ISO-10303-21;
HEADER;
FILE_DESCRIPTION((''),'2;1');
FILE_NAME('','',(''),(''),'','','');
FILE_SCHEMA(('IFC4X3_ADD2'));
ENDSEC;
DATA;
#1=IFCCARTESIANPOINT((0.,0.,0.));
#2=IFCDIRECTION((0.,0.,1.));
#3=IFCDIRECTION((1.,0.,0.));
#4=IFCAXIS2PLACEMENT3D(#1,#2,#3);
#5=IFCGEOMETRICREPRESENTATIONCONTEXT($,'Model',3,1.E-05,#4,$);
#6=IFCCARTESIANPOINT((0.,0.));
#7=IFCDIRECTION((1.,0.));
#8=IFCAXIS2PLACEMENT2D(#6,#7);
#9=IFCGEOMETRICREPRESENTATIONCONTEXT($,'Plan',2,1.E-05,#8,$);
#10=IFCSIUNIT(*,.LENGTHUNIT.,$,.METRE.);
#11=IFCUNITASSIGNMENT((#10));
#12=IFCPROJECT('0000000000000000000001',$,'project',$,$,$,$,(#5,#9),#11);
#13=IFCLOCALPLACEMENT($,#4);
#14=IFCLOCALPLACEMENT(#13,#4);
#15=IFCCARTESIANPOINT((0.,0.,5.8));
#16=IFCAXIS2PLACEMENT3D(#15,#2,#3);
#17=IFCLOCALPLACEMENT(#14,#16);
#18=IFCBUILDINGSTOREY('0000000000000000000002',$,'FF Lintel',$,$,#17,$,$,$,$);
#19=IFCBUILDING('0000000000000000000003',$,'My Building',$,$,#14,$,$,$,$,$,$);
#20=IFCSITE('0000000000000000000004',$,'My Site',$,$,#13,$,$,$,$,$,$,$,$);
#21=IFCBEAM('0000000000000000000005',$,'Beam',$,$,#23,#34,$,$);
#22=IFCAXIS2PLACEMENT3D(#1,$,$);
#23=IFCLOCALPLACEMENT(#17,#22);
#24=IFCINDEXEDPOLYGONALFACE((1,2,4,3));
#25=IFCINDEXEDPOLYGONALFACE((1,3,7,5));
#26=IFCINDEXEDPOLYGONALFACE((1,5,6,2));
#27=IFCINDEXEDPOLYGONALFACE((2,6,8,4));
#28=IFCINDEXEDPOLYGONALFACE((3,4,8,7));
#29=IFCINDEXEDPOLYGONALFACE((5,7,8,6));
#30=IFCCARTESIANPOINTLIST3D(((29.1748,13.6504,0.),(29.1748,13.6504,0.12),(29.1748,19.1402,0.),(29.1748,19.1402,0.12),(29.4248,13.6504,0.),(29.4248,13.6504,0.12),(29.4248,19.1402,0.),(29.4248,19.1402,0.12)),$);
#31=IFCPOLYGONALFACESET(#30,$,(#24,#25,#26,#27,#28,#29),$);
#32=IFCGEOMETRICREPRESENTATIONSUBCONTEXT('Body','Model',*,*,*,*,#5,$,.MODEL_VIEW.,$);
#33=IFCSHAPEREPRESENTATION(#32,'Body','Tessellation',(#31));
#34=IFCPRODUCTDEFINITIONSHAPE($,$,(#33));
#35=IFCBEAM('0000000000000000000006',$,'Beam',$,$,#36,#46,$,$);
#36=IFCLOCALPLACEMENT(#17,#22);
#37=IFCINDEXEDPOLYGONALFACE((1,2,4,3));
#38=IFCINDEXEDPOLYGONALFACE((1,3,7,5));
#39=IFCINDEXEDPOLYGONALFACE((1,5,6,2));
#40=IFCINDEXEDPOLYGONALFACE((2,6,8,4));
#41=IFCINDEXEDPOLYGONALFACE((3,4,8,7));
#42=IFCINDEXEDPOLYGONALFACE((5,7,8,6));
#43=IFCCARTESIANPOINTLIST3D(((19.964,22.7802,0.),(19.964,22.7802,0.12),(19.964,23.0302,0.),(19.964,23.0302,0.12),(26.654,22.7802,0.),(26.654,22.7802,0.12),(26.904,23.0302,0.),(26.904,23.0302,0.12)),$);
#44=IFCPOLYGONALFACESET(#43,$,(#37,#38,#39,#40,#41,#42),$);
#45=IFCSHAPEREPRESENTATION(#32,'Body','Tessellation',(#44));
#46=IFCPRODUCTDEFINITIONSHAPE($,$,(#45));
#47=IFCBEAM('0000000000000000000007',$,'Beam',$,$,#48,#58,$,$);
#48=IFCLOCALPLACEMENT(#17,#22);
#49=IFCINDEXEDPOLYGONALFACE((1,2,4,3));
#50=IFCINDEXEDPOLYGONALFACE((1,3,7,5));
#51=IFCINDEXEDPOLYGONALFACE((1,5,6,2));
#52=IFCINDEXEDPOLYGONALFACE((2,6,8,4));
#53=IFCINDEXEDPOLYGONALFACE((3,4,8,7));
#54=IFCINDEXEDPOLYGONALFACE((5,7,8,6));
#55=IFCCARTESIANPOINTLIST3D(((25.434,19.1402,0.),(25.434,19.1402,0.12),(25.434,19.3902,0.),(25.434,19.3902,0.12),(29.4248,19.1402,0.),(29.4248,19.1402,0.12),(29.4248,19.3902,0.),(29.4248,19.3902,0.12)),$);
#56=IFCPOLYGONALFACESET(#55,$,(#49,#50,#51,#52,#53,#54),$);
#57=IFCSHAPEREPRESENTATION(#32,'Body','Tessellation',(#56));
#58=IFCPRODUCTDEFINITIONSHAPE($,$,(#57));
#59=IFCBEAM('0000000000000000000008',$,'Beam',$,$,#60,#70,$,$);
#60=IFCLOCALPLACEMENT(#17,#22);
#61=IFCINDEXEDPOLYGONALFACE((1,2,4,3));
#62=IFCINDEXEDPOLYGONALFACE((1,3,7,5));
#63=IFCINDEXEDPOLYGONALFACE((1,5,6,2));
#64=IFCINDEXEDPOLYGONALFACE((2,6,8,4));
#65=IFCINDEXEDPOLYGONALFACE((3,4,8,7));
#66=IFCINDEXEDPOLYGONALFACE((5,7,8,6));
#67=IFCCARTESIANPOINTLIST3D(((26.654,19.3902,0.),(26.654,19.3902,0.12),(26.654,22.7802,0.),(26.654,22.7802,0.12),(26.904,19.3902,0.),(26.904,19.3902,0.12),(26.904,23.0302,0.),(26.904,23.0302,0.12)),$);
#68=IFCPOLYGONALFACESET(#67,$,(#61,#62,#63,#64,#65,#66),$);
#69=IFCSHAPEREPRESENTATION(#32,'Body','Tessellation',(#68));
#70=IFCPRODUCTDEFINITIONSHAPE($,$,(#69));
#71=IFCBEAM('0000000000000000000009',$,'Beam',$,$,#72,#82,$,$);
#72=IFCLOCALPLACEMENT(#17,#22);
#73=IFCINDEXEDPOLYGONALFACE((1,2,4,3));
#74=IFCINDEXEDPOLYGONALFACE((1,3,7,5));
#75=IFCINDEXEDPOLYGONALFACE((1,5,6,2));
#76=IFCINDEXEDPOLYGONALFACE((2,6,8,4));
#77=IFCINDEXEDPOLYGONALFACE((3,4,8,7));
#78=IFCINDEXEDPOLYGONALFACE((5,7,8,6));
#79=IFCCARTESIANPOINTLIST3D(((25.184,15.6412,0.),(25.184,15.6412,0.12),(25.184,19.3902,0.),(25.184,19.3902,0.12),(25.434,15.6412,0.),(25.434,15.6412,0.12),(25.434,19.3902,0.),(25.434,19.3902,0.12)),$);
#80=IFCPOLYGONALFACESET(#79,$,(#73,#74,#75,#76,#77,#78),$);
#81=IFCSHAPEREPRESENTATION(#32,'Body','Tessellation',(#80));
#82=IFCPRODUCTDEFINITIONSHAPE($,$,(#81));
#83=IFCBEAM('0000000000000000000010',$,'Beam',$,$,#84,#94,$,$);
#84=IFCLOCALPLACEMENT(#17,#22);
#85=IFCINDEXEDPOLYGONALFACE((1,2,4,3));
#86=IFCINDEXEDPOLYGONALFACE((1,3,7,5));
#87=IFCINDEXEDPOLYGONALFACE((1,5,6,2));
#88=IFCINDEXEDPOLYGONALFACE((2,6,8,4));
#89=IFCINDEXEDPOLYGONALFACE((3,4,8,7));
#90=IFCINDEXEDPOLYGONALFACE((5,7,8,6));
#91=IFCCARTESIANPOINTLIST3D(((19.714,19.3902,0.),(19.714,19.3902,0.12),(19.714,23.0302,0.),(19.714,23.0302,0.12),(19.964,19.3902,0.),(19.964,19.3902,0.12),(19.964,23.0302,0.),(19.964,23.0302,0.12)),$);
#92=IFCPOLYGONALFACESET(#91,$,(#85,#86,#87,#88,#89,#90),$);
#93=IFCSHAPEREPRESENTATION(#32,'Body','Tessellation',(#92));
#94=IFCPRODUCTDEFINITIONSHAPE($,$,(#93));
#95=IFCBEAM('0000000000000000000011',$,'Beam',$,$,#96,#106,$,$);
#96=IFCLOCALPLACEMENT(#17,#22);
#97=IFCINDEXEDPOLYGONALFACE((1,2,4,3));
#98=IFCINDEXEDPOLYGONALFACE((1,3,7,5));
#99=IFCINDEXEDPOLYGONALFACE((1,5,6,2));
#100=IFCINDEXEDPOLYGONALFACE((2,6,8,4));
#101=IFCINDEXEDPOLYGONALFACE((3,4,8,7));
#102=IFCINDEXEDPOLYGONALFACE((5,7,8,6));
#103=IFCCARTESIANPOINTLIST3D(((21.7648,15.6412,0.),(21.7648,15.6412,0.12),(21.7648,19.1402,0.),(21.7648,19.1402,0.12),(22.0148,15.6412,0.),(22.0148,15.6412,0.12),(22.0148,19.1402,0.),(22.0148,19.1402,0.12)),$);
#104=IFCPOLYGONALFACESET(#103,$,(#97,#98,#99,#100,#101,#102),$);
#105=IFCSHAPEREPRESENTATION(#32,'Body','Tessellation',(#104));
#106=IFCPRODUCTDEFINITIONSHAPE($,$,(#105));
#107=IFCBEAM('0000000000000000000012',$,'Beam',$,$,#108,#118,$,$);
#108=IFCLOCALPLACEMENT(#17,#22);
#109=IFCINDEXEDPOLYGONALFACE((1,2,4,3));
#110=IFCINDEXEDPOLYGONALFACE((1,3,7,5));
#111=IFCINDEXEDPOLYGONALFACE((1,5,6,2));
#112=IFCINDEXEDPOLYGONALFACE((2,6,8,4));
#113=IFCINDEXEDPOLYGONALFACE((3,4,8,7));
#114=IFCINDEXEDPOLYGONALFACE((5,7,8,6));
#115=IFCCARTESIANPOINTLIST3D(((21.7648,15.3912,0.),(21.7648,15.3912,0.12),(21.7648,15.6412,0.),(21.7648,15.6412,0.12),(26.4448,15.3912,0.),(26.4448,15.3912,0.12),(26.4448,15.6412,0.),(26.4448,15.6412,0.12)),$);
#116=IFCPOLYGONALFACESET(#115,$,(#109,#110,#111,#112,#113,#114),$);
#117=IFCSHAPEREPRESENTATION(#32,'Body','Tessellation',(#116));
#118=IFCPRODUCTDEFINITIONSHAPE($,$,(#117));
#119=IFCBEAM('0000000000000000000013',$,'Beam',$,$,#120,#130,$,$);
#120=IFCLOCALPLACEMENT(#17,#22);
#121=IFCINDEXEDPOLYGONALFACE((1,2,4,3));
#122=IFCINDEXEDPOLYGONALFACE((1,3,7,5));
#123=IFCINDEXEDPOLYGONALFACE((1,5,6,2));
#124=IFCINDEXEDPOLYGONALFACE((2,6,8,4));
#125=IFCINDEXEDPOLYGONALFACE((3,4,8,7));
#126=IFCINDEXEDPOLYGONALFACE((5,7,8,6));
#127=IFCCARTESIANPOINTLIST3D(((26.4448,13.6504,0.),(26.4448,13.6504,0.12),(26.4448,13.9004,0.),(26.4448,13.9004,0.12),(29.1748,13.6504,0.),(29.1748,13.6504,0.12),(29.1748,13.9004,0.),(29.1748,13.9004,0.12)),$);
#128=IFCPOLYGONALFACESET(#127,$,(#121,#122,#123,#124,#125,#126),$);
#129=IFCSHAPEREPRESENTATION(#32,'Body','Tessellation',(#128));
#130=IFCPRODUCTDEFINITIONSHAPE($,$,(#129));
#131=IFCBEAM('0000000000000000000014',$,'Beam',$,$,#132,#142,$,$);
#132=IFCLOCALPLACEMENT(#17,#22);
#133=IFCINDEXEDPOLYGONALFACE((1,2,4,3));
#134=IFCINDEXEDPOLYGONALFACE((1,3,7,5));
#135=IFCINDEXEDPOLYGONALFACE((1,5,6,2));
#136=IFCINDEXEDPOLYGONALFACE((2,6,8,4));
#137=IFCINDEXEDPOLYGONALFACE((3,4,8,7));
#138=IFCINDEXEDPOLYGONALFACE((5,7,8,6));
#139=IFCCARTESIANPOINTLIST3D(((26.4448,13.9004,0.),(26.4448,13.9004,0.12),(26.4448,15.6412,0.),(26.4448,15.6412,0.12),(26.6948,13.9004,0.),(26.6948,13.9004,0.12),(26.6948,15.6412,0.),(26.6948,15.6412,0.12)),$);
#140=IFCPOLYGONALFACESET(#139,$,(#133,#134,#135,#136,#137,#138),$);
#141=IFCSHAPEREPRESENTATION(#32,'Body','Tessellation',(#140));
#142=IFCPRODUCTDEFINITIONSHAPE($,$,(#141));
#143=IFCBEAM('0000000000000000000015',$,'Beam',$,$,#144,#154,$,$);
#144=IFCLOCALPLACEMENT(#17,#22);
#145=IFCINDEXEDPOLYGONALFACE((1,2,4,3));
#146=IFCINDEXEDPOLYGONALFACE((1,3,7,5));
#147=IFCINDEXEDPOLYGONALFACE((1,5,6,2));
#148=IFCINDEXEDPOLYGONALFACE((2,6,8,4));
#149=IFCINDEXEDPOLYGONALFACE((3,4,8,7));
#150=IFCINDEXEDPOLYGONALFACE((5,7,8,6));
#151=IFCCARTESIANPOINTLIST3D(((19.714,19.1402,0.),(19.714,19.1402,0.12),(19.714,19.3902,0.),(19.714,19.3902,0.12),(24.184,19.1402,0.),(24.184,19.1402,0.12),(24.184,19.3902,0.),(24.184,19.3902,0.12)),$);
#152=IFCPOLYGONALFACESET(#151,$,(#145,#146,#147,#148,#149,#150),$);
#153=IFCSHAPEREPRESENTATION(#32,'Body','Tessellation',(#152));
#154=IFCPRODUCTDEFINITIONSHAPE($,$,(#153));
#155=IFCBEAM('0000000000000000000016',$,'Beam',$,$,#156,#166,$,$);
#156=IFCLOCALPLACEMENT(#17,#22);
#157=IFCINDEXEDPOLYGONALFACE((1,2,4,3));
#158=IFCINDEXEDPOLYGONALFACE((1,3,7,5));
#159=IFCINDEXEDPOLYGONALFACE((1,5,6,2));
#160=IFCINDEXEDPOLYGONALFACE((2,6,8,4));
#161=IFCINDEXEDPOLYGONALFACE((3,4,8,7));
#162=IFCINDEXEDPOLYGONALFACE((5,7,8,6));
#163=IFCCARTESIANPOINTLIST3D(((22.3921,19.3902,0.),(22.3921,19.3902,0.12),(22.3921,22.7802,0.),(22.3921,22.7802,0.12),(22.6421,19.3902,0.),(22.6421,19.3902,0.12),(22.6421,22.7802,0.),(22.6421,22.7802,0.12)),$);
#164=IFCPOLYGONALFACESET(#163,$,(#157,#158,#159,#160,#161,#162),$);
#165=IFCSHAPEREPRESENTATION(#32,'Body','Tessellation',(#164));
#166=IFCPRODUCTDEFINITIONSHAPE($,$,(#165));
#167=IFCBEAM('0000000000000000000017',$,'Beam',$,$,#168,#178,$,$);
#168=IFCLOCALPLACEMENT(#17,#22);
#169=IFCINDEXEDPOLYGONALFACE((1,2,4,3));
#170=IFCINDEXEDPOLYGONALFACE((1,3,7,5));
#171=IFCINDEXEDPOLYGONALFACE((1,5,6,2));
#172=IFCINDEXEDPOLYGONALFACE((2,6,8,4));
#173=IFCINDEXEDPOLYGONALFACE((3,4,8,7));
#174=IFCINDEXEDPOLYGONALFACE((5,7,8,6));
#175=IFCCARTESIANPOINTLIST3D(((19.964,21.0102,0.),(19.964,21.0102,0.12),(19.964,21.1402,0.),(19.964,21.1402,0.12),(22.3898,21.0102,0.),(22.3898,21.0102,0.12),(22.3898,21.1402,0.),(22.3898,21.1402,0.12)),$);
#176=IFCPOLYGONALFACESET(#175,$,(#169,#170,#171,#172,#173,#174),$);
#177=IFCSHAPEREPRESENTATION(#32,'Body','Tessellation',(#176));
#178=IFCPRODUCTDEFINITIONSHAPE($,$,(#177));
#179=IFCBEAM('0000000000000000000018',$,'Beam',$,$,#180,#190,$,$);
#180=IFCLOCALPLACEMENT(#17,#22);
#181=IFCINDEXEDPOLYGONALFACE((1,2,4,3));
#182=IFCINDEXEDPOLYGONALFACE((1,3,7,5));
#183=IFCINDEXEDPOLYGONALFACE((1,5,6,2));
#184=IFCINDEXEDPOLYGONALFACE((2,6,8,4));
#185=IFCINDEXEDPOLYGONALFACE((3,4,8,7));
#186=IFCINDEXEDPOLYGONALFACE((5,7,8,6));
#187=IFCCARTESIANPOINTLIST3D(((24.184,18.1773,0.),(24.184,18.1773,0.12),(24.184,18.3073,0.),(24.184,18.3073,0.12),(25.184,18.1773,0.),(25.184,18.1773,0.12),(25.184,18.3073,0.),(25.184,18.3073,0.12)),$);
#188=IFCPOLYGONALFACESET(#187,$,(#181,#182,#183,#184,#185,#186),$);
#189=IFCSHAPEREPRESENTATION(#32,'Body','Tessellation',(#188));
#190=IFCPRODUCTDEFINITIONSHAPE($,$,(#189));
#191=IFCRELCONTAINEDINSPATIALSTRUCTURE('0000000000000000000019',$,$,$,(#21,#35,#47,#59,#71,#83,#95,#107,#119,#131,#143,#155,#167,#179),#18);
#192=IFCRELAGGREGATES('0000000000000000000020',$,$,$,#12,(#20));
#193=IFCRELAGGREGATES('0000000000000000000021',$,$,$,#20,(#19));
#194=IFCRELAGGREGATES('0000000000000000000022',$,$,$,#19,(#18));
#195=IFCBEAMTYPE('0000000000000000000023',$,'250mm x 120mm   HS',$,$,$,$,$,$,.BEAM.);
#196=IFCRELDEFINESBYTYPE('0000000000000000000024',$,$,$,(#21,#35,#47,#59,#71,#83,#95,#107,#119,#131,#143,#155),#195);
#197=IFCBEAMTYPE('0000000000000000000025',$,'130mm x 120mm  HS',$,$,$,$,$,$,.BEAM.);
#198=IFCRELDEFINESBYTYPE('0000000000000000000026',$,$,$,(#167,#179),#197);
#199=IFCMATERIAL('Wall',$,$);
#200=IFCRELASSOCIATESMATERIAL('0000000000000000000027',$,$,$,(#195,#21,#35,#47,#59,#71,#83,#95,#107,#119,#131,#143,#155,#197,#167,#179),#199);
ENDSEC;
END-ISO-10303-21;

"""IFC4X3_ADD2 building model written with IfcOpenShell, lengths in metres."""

from ifc_helpers import new_model, si_unit, frame, origin_with_axes, origin_2d_with_axis, place, context, subcontext, project, spatial, rectangle, extrude, clip, halfspace, material, material_profile, profile_set, profile_usage, type_object, element, save


model = new_model("IFC4X3_ADD2")

# Units and contexts
model_context = context("Model", 3, precision=1e-05, world=origin_with_axes())
plan_context = context("Plan", 2, precision=1e-05, world=origin_2d_with_axis())
body_context = subcontext(model_context, "Body", "Model", "MODEL_VIEW")
ifc_project = project(units=[si_unit("LENGTHUNIT", "METRE")], contexts=[model_context, plan_context])

# Site, building, storey
site_placement = place(None, origin_with_axes())
site = spatial("IfcSite", under=ifc_project, at=site_placement, Name="My Site")
building_placement = place(site_placement, origin_with_axes())
building = spatial("IfcBuilding", under=site, at=building_placement, Name="My Building")
storey_placement = place(building_placement, frame((0.0, 0.0, 5.8), z_axis=(0.0, 0.0, 1.0), x_axis=(1.0, 0.0, 0.0)))
storey = spatial("IfcBuildingStorey", under=building, at=storey_placement, Name="FF Lintel")

# Beams
ifc_material_1 = material(Name="Wall")
ifc_material_profile_1 = material_profile(ifc_material_1, rectangle(XDim=0.25, YDim=0.12))
ifc_profile_set_1 = profile_set([ifc_material_profile_1], Name="concrete")
ifc_profile_usage_1 = profile_usage(ifc_profile_set_1)
beam_type_1 = type_object("IfcBeamType", Name="250mm x 120mm   HS", PredefinedType="BEAM", material=ifc_profile_set_1)
beam_1_placement = place(storey_placement, frame((29.2998, 19.1402, 0.06), z_axis=(0.0, -1.0, 0.0), x_axis=(1.0, 0.0, 0.0)))
element("IfcBeam", 1, at=beam_1_placement, inside=storey, type_object=beam_type_1, material=ifc_profile_usage_1, Name="Beam", context=body_context, shape_type="SweptSolid", body=[
    extrude(rectangle(XDim=0.25, YDim=0.12), origin_with_axes(), (0.0, 0.0, 1.0), 5.4898),
])
ifc_profile_usage_2 = profile_usage(ifc_profile_set_1)
beam_2_placement = place(storey_placement, frame((26.904, 22.9052, 0.06), z_axis=(-1.0, 0.0, 0.0), x_axis=(0.0, -1.0, 0.0)))
element("IfcBeam", 2, at=beam_2_placement, inside=storey, type_object=beam_type_1, material=ifc_profile_usage_2, Name="Beam", context=body_context, shape_type="Clipping", body=[
    clip(extrude(rectangle(XDim=0.25, YDim=0.12), origin_with_axes(), (0.0, 0.0, 1.0), 6.94), halfspace(frame((-0.125, -2.66, 0.0), z_axis=(0.707106, 0.0, -0.707107), x_axis=(0.0, -1.0, 0.0)), False)),
])
ifc_profile_usage_3 = profile_usage(ifc_profile_set_1)
beam_3_placement = place(storey_placement, frame((29.4248, 19.2652, 0.06), z_axis=(-1.0, 0.0, 0.0), x_axis=(0.0, -1.0, 0.0)))
element("IfcBeam", 3, at=beam_3_placement, inside=storey, type_object=beam_type_1, material=ifc_profile_usage_3, Name="Beam", context=body_context, shape_type="SweptSolid", body=[
    extrude(rectangle(XDim=0.25, YDim=0.12), origin_with_axes(), (0.0, 0.0, 1.0), 3.9908),
])
ifc_profile_usage_4 = profile_usage(ifc_profile_set_1)
beam_4_placement = place(storey_placement, frame((26.779, 23.0302, 0.06), z_axis=(0.0, -1.0, 0.0), x_axis=(1.0, 0.0, 0.0)))
element("IfcBeam", 4, at=beam_4_placement, inside=storey, type_object=beam_type_1, material=ifc_profile_usage_4, Name="Beam", context=body_context, shape_type="Clipping", body=[
    clip(extrude(rectangle(XDim=0.25, YDim=0.12), origin_with_axes(), (0.0, 0.0, 1.0), 3.64), halfspace(frame((0.125, -2.66, 0.0), z_axis=(-0.707107, 0.0, -0.707107), x_axis=(0.0, 1.0, 0.0)), False)),
])
ifc_profile_usage_5 = profile_usage(ifc_profile_set_1)
beam_5_placement = place(storey_placement, frame((25.309, 19.3902, 0.06), z_axis=(0.0, -1.0, 0.0), x_axis=(1.0, 0.0, 0.0)))
element("IfcBeam", 5, at=beam_5_placement, inside=storey, type_object=beam_type_1, material=ifc_profile_usage_5, Name="Beam", context=body_context, shape_type="SweptSolid", body=[
    extrude(rectangle(XDim=0.25, YDim=0.12), origin_with_axes(), (0.0, 0.0, 1.0), 3.749),
])
ifc_profile_usage_6 = profile_usage(ifc_profile_set_1)
beam_6_placement = place(storey_placement, frame((19.839, 23.0302, 0.06), z_axis=(0.0, -1.0, 0.0), x_axis=(1.0, 0.0, 0.0)))
element("IfcBeam", 6, at=beam_6_placement, inside=storey, type_object=beam_type_1, material=ifc_profile_usage_6, Name="Beam", context=body_context, shape_type="SweptSolid", body=[
    extrude(rectangle(XDim=0.25, YDim=0.12), origin_with_axes(), (0.0, 0.0, 1.0), 3.64),
])
ifc_profile_usage_7 = profile_usage(ifc_profile_set_1)
beam_7_placement = place(storey_placement, frame((21.8898, 19.1402, 0.06), z_axis=(0.0, -1.0, 0.0), x_axis=(1.0, 0.0, 0.0)))
element("IfcBeam", 7, at=beam_7_placement, inside=storey, type_object=beam_type_1, material=ifc_profile_usage_7, Name="Beam", context=body_context, shape_type="SweptSolid", body=[
    extrude(rectangle(XDim=0.25, YDim=0.12), origin_with_axes(), (0.0, 0.0, 1.0), 3.499),
])
ifc_profile_usage_8 = profile_usage(ifc_profile_set_1)
beam_8_placement = place(storey_placement, frame((26.4448, 15.5162, 0.06), z_axis=(-1.0, 0.0, 0.0), x_axis=(0.0, -1.0, 0.0)))
element("IfcBeam", 8, at=beam_8_placement, inside=storey, type_object=beam_type_1, material=ifc_profile_usage_8, Name="Beam", context=body_context, shape_type="SweptSolid", body=[
    extrude(rectangle(XDim=0.25, YDim=0.12), origin_with_axes(), (0.0, 0.0, 1.0), 4.68),
])
ifc_profile_usage_9 = profile_usage(ifc_profile_set_1)
beam_9_placement = place(storey_placement, frame((29.1748, 13.7754, 0.06), z_axis=(-1.0, 0.0, 0.0), x_axis=(0.0, -1.0, 0.0)))
element("IfcBeam", 9, at=beam_9_placement, inside=storey, type_object=beam_type_1, material=ifc_profile_usage_9, Name="Beam", context=body_context, shape_type="SweptSolid", body=[
    extrude(rectangle(XDim=0.25, YDim=0.12), origin_with_axes(), (0.0, 0.0, 1.0), 2.73),
])
ifc_profile_usage_10 = profile_usage(ifc_profile_set_1)
beam_10_placement = place(storey_placement, frame((26.5698, 15.6412, 0.06), z_axis=(0.0, -1.0, 0.0), x_axis=(1.0, 0.0, 0.0)))
element("IfcBeam", 10, at=beam_10_placement, inside=storey, type_object=beam_type_1, material=ifc_profile_usage_10, Name="Beam", context=body_context, shape_type="SweptSolid", body=[
    extrude(rectangle(XDim=0.25, YDim=0.12), origin_with_axes(), (0.0, 0.0, 1.0), 1.7408),
])
ifc_profile_usage_11 = profile_usage(ifc_profile_set_1)
beam_11_placement = place(storey_placement, frame((24.184, 19.2652, 0.06), z_axis=(-1.0, 0.0, 0.0), x_axis=(0.0, -1.0, 0.0)))
element("IfcBeam", 11, at=beam_11_placement, inside=storey, type_object=beam_type_1, material=ifc_profile_usage_11, Name="Beam", context=body_context, shape_type="SweptSolid", body=[
    extrude(rectangle(XDim=0.25, YDim=0.12), origin_with_axes(), (0.0, 0.0, 1.0), 4.47),
])
ifc_profile_usage_12 = profile_usage(ifc_profile_set_1)
beam_12_placement = place(storey_placement, frame((22.5171, 22.7802, 0.06), z_axis=(0.0, -1.0, 0.0), x_axis=(1.0, 0.0, 0.0)))
element("IfcBeam", 12, at=beam_12_placement, inside=storey, type_object=beam_type_1, material=ifc_profile_usage_12, Name="Beam", context=body_context, shape_type="SweptSolid", body=[
    extrude(rectangle(XDim=0.25, YDim=0.12), origin_with_axes(), (0.0, 0.0, 1.0), 3.39),
])
ifc_material_profile_2 = material_profile(ifc_material_1, rectangle(XDim=0.13, YDim=0.12))
ifc_profile_set_2 = profile_set([ifc_material_profile_2], Name="concrete")
ifc_profile_usage_13 = profile_usage(ifc_profile_set_2)
beam_type_2 = type_object("IfcBeamType", Name="130mm x 120mm  HS", PredefinedType="BEAM", material=ifc_profile_set_2)
beam_13_placement = place(storey_placement, frame((22.3898, 21.0752, 0.06), z_axis=(-1.0, 0.0, 0.0), x_axis=(0.0, -1.0, 0.0)))
element("IfcBeam", 13, at=beam_13_placement, inside=storey, type_object=beam_type_2, material=ifc_profile_usage_13, Name="Beam", context=body_context, shape_type="SweptSolid", body=[
    extrude(rectangle(XDim=0.13, YDim=0.12), origin_with_axes(), (0.0, 0.0, 1.0), 2.4258),
])
ifc_profile_usage_14 = profile_usage(ifc_profile_set_2)
beam_14_placement = place(storey_placement, frame((25.184, 18.2423, 0.06), z_axis=(-1.0, 0.0, 0.0), x_axis=(0.0, -1.0, 0.0)))
element("IfcBeam", 14, at=beam_14_placement, inside=storey, type_object=beam_type_2, material=ifc_profile_usage_14, Name="Beam", context=body_context, shape_type="SweptSolid", body=[
    extrude(rectangle(XDim=0.13, YDim=0.12), origin_with_axes(), (0.0, 0.0, 1.0), 1.0),
])

save(model, "model.ifc")
